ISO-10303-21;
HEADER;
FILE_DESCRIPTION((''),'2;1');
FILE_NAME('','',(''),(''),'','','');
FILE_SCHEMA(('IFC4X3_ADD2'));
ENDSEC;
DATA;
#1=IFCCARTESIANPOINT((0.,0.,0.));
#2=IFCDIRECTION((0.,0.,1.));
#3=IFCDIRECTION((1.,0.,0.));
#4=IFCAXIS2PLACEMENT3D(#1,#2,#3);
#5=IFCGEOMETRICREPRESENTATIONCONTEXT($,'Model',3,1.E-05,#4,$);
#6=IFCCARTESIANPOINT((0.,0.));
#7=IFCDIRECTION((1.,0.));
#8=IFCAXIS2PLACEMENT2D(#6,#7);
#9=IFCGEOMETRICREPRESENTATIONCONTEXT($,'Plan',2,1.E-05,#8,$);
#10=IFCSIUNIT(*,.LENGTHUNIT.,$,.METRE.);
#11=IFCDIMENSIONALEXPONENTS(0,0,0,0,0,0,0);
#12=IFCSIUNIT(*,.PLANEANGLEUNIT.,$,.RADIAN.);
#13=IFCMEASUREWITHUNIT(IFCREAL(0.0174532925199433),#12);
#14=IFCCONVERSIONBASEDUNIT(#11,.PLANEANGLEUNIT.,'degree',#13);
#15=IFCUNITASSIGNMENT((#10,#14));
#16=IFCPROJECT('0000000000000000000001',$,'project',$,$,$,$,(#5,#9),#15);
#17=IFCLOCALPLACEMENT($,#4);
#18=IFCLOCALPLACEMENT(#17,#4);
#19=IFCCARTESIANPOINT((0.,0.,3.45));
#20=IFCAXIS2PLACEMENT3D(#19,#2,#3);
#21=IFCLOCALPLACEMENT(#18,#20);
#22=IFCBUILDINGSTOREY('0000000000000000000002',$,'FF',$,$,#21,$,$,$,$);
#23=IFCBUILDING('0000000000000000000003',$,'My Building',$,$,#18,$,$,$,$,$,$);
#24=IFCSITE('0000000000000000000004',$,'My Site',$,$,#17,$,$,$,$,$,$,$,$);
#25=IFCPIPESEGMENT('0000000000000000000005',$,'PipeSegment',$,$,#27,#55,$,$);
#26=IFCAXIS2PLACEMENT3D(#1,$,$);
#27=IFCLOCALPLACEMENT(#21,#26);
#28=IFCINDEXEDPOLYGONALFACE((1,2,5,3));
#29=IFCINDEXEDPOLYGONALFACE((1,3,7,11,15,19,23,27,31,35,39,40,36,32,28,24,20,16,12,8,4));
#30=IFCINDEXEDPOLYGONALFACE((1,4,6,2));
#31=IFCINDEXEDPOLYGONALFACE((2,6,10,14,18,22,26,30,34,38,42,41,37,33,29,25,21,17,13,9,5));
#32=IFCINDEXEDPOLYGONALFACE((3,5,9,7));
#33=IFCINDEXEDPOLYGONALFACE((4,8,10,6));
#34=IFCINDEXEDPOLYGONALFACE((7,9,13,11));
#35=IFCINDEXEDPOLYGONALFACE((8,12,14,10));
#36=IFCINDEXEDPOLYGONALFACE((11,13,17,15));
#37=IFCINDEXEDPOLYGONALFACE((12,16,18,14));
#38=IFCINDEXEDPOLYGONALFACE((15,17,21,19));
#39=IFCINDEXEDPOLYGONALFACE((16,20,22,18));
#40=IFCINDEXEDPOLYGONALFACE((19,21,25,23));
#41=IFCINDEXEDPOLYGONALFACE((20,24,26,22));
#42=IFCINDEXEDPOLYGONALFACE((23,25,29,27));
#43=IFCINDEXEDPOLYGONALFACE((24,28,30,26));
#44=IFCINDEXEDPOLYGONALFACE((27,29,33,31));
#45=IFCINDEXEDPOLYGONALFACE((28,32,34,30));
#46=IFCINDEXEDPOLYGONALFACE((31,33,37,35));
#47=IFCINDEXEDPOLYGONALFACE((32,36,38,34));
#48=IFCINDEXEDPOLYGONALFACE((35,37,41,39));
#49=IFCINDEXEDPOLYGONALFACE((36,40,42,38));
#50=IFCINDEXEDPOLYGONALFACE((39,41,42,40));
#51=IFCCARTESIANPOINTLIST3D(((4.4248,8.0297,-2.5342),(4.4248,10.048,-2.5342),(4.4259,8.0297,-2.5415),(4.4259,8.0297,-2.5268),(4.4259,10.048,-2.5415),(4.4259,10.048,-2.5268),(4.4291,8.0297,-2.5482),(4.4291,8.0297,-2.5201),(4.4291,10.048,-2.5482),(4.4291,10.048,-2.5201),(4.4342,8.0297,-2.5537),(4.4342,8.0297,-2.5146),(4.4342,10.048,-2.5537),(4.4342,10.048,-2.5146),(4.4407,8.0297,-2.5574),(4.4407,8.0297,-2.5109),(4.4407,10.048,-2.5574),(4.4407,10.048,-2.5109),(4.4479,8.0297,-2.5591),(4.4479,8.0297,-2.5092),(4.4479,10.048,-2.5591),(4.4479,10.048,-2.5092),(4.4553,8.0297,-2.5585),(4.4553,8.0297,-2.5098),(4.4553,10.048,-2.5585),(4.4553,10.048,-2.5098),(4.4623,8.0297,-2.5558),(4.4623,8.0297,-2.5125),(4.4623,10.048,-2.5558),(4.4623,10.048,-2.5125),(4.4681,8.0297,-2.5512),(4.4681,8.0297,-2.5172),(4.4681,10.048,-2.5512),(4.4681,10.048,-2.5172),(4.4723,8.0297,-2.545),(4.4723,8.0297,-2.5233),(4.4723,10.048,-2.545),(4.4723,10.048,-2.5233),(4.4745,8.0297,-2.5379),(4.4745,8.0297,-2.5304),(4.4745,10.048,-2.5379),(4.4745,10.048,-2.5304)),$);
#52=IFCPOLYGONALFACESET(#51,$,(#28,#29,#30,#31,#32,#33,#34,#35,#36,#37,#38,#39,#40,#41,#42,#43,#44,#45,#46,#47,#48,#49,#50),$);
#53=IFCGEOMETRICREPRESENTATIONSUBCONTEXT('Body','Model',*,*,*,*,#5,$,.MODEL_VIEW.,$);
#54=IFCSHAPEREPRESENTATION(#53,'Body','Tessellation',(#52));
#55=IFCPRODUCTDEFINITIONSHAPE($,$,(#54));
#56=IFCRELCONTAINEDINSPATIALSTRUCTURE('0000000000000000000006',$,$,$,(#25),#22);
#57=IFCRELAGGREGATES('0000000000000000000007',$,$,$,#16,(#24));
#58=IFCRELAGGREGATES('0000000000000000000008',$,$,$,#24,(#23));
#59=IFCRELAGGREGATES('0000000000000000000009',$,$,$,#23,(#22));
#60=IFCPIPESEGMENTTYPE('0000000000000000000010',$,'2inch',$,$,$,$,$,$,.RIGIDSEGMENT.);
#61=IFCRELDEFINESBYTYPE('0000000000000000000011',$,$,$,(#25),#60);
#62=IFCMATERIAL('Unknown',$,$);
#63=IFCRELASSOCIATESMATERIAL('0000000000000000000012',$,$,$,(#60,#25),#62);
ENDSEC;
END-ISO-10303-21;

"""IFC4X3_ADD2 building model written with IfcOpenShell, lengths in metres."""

from ifc_helpers import new_model, entity, si_unit, converted_unit, frame, origin_with_axes, origin_2d_with_axis, place, context, subcontext, project, spatial, circle, extrude, material, material_profile, profile_set, profile_usage, type_object, element, save


model = new_model("IFC4X3_ADD2")

# Units and contexts
model_context = context("Model", 3, precision=1e-05, world=origin_with_axes())
plan_context = context("Plan", 2, precision=1e-05, world=origin_2d_with_axis())
body_context_1 = subcontext(model_context, "Body", "Model", "MODEL_VIEW")
ifc_project = project(units=[si_unit("LENGTHUNIT", "METRE"), converted_unit("PLANEANGLEUNIT", "degree", entity("IfcReal", 0.0174532925199433), si_unit("PLANEANGLEUNIT", "RADIAN"), dimensions=[0, 0, 0, 0, 0, 0, 0])], contexts=[model_context, plan_context])

# Site, building, storey
site_placement = place(None, origin_with_axes())
site = spatial("IfcSite", under=ifc_project, at=site_placement, Name="My Site")
building_placement = place(site_placement, origin_with_axes())
building = spatial("IfcBuilding", under=site, at=building_placement, Name="My Building")
storey_placement = place(building_placement, frame((0.0, 0.0, 3.45), z_axis=(0.0, 0.0, 1.0), x_axis=(1.0, 0.0, 0.0)))
storey = spatial("IfcBuildingStorey", under=building, at=storey_placement, Name="FF")

# Shared definitions
ifc_material = material(Name="Unknown")

# Pipe segment
ifc_material_profile_1 = material_profile(ifc_material, circle(Radius=0.025))
ifc_profile_set_1 = profile_set([ifc_material_profile_1])
pipe_segment_type_1 = type_object("IfcPipeSegmentType", Name="2inch", PredefinedType="RIGIDSEGMENT", material=ifc_profile_set_1)
ifc_profile_usage_1 = profile_usage(ifc_profile_set_1)
pipe_segment_1_placement = place(storey_placement, frame((4.4498, 8.0297, -2.5342), z_axis=(0.0, 1.0, 0.0), x_axis=(-1.0, 0.0, 0.0)))
element("IfcPipeSegment", 1, at=pipe_segment_1_placement, inside=storey, type_object=pipe_segment_type_1, material=ifc_profile_usage_1, Name="PipeSegment", context=body_context_1, shape_type="SweptSolid", body=[
    extrude(circle(Radius=0.025), origin_with_axes(), (0.0, 0.0, 1.0), 2.0184),
])

save(model, "model.ifc")
